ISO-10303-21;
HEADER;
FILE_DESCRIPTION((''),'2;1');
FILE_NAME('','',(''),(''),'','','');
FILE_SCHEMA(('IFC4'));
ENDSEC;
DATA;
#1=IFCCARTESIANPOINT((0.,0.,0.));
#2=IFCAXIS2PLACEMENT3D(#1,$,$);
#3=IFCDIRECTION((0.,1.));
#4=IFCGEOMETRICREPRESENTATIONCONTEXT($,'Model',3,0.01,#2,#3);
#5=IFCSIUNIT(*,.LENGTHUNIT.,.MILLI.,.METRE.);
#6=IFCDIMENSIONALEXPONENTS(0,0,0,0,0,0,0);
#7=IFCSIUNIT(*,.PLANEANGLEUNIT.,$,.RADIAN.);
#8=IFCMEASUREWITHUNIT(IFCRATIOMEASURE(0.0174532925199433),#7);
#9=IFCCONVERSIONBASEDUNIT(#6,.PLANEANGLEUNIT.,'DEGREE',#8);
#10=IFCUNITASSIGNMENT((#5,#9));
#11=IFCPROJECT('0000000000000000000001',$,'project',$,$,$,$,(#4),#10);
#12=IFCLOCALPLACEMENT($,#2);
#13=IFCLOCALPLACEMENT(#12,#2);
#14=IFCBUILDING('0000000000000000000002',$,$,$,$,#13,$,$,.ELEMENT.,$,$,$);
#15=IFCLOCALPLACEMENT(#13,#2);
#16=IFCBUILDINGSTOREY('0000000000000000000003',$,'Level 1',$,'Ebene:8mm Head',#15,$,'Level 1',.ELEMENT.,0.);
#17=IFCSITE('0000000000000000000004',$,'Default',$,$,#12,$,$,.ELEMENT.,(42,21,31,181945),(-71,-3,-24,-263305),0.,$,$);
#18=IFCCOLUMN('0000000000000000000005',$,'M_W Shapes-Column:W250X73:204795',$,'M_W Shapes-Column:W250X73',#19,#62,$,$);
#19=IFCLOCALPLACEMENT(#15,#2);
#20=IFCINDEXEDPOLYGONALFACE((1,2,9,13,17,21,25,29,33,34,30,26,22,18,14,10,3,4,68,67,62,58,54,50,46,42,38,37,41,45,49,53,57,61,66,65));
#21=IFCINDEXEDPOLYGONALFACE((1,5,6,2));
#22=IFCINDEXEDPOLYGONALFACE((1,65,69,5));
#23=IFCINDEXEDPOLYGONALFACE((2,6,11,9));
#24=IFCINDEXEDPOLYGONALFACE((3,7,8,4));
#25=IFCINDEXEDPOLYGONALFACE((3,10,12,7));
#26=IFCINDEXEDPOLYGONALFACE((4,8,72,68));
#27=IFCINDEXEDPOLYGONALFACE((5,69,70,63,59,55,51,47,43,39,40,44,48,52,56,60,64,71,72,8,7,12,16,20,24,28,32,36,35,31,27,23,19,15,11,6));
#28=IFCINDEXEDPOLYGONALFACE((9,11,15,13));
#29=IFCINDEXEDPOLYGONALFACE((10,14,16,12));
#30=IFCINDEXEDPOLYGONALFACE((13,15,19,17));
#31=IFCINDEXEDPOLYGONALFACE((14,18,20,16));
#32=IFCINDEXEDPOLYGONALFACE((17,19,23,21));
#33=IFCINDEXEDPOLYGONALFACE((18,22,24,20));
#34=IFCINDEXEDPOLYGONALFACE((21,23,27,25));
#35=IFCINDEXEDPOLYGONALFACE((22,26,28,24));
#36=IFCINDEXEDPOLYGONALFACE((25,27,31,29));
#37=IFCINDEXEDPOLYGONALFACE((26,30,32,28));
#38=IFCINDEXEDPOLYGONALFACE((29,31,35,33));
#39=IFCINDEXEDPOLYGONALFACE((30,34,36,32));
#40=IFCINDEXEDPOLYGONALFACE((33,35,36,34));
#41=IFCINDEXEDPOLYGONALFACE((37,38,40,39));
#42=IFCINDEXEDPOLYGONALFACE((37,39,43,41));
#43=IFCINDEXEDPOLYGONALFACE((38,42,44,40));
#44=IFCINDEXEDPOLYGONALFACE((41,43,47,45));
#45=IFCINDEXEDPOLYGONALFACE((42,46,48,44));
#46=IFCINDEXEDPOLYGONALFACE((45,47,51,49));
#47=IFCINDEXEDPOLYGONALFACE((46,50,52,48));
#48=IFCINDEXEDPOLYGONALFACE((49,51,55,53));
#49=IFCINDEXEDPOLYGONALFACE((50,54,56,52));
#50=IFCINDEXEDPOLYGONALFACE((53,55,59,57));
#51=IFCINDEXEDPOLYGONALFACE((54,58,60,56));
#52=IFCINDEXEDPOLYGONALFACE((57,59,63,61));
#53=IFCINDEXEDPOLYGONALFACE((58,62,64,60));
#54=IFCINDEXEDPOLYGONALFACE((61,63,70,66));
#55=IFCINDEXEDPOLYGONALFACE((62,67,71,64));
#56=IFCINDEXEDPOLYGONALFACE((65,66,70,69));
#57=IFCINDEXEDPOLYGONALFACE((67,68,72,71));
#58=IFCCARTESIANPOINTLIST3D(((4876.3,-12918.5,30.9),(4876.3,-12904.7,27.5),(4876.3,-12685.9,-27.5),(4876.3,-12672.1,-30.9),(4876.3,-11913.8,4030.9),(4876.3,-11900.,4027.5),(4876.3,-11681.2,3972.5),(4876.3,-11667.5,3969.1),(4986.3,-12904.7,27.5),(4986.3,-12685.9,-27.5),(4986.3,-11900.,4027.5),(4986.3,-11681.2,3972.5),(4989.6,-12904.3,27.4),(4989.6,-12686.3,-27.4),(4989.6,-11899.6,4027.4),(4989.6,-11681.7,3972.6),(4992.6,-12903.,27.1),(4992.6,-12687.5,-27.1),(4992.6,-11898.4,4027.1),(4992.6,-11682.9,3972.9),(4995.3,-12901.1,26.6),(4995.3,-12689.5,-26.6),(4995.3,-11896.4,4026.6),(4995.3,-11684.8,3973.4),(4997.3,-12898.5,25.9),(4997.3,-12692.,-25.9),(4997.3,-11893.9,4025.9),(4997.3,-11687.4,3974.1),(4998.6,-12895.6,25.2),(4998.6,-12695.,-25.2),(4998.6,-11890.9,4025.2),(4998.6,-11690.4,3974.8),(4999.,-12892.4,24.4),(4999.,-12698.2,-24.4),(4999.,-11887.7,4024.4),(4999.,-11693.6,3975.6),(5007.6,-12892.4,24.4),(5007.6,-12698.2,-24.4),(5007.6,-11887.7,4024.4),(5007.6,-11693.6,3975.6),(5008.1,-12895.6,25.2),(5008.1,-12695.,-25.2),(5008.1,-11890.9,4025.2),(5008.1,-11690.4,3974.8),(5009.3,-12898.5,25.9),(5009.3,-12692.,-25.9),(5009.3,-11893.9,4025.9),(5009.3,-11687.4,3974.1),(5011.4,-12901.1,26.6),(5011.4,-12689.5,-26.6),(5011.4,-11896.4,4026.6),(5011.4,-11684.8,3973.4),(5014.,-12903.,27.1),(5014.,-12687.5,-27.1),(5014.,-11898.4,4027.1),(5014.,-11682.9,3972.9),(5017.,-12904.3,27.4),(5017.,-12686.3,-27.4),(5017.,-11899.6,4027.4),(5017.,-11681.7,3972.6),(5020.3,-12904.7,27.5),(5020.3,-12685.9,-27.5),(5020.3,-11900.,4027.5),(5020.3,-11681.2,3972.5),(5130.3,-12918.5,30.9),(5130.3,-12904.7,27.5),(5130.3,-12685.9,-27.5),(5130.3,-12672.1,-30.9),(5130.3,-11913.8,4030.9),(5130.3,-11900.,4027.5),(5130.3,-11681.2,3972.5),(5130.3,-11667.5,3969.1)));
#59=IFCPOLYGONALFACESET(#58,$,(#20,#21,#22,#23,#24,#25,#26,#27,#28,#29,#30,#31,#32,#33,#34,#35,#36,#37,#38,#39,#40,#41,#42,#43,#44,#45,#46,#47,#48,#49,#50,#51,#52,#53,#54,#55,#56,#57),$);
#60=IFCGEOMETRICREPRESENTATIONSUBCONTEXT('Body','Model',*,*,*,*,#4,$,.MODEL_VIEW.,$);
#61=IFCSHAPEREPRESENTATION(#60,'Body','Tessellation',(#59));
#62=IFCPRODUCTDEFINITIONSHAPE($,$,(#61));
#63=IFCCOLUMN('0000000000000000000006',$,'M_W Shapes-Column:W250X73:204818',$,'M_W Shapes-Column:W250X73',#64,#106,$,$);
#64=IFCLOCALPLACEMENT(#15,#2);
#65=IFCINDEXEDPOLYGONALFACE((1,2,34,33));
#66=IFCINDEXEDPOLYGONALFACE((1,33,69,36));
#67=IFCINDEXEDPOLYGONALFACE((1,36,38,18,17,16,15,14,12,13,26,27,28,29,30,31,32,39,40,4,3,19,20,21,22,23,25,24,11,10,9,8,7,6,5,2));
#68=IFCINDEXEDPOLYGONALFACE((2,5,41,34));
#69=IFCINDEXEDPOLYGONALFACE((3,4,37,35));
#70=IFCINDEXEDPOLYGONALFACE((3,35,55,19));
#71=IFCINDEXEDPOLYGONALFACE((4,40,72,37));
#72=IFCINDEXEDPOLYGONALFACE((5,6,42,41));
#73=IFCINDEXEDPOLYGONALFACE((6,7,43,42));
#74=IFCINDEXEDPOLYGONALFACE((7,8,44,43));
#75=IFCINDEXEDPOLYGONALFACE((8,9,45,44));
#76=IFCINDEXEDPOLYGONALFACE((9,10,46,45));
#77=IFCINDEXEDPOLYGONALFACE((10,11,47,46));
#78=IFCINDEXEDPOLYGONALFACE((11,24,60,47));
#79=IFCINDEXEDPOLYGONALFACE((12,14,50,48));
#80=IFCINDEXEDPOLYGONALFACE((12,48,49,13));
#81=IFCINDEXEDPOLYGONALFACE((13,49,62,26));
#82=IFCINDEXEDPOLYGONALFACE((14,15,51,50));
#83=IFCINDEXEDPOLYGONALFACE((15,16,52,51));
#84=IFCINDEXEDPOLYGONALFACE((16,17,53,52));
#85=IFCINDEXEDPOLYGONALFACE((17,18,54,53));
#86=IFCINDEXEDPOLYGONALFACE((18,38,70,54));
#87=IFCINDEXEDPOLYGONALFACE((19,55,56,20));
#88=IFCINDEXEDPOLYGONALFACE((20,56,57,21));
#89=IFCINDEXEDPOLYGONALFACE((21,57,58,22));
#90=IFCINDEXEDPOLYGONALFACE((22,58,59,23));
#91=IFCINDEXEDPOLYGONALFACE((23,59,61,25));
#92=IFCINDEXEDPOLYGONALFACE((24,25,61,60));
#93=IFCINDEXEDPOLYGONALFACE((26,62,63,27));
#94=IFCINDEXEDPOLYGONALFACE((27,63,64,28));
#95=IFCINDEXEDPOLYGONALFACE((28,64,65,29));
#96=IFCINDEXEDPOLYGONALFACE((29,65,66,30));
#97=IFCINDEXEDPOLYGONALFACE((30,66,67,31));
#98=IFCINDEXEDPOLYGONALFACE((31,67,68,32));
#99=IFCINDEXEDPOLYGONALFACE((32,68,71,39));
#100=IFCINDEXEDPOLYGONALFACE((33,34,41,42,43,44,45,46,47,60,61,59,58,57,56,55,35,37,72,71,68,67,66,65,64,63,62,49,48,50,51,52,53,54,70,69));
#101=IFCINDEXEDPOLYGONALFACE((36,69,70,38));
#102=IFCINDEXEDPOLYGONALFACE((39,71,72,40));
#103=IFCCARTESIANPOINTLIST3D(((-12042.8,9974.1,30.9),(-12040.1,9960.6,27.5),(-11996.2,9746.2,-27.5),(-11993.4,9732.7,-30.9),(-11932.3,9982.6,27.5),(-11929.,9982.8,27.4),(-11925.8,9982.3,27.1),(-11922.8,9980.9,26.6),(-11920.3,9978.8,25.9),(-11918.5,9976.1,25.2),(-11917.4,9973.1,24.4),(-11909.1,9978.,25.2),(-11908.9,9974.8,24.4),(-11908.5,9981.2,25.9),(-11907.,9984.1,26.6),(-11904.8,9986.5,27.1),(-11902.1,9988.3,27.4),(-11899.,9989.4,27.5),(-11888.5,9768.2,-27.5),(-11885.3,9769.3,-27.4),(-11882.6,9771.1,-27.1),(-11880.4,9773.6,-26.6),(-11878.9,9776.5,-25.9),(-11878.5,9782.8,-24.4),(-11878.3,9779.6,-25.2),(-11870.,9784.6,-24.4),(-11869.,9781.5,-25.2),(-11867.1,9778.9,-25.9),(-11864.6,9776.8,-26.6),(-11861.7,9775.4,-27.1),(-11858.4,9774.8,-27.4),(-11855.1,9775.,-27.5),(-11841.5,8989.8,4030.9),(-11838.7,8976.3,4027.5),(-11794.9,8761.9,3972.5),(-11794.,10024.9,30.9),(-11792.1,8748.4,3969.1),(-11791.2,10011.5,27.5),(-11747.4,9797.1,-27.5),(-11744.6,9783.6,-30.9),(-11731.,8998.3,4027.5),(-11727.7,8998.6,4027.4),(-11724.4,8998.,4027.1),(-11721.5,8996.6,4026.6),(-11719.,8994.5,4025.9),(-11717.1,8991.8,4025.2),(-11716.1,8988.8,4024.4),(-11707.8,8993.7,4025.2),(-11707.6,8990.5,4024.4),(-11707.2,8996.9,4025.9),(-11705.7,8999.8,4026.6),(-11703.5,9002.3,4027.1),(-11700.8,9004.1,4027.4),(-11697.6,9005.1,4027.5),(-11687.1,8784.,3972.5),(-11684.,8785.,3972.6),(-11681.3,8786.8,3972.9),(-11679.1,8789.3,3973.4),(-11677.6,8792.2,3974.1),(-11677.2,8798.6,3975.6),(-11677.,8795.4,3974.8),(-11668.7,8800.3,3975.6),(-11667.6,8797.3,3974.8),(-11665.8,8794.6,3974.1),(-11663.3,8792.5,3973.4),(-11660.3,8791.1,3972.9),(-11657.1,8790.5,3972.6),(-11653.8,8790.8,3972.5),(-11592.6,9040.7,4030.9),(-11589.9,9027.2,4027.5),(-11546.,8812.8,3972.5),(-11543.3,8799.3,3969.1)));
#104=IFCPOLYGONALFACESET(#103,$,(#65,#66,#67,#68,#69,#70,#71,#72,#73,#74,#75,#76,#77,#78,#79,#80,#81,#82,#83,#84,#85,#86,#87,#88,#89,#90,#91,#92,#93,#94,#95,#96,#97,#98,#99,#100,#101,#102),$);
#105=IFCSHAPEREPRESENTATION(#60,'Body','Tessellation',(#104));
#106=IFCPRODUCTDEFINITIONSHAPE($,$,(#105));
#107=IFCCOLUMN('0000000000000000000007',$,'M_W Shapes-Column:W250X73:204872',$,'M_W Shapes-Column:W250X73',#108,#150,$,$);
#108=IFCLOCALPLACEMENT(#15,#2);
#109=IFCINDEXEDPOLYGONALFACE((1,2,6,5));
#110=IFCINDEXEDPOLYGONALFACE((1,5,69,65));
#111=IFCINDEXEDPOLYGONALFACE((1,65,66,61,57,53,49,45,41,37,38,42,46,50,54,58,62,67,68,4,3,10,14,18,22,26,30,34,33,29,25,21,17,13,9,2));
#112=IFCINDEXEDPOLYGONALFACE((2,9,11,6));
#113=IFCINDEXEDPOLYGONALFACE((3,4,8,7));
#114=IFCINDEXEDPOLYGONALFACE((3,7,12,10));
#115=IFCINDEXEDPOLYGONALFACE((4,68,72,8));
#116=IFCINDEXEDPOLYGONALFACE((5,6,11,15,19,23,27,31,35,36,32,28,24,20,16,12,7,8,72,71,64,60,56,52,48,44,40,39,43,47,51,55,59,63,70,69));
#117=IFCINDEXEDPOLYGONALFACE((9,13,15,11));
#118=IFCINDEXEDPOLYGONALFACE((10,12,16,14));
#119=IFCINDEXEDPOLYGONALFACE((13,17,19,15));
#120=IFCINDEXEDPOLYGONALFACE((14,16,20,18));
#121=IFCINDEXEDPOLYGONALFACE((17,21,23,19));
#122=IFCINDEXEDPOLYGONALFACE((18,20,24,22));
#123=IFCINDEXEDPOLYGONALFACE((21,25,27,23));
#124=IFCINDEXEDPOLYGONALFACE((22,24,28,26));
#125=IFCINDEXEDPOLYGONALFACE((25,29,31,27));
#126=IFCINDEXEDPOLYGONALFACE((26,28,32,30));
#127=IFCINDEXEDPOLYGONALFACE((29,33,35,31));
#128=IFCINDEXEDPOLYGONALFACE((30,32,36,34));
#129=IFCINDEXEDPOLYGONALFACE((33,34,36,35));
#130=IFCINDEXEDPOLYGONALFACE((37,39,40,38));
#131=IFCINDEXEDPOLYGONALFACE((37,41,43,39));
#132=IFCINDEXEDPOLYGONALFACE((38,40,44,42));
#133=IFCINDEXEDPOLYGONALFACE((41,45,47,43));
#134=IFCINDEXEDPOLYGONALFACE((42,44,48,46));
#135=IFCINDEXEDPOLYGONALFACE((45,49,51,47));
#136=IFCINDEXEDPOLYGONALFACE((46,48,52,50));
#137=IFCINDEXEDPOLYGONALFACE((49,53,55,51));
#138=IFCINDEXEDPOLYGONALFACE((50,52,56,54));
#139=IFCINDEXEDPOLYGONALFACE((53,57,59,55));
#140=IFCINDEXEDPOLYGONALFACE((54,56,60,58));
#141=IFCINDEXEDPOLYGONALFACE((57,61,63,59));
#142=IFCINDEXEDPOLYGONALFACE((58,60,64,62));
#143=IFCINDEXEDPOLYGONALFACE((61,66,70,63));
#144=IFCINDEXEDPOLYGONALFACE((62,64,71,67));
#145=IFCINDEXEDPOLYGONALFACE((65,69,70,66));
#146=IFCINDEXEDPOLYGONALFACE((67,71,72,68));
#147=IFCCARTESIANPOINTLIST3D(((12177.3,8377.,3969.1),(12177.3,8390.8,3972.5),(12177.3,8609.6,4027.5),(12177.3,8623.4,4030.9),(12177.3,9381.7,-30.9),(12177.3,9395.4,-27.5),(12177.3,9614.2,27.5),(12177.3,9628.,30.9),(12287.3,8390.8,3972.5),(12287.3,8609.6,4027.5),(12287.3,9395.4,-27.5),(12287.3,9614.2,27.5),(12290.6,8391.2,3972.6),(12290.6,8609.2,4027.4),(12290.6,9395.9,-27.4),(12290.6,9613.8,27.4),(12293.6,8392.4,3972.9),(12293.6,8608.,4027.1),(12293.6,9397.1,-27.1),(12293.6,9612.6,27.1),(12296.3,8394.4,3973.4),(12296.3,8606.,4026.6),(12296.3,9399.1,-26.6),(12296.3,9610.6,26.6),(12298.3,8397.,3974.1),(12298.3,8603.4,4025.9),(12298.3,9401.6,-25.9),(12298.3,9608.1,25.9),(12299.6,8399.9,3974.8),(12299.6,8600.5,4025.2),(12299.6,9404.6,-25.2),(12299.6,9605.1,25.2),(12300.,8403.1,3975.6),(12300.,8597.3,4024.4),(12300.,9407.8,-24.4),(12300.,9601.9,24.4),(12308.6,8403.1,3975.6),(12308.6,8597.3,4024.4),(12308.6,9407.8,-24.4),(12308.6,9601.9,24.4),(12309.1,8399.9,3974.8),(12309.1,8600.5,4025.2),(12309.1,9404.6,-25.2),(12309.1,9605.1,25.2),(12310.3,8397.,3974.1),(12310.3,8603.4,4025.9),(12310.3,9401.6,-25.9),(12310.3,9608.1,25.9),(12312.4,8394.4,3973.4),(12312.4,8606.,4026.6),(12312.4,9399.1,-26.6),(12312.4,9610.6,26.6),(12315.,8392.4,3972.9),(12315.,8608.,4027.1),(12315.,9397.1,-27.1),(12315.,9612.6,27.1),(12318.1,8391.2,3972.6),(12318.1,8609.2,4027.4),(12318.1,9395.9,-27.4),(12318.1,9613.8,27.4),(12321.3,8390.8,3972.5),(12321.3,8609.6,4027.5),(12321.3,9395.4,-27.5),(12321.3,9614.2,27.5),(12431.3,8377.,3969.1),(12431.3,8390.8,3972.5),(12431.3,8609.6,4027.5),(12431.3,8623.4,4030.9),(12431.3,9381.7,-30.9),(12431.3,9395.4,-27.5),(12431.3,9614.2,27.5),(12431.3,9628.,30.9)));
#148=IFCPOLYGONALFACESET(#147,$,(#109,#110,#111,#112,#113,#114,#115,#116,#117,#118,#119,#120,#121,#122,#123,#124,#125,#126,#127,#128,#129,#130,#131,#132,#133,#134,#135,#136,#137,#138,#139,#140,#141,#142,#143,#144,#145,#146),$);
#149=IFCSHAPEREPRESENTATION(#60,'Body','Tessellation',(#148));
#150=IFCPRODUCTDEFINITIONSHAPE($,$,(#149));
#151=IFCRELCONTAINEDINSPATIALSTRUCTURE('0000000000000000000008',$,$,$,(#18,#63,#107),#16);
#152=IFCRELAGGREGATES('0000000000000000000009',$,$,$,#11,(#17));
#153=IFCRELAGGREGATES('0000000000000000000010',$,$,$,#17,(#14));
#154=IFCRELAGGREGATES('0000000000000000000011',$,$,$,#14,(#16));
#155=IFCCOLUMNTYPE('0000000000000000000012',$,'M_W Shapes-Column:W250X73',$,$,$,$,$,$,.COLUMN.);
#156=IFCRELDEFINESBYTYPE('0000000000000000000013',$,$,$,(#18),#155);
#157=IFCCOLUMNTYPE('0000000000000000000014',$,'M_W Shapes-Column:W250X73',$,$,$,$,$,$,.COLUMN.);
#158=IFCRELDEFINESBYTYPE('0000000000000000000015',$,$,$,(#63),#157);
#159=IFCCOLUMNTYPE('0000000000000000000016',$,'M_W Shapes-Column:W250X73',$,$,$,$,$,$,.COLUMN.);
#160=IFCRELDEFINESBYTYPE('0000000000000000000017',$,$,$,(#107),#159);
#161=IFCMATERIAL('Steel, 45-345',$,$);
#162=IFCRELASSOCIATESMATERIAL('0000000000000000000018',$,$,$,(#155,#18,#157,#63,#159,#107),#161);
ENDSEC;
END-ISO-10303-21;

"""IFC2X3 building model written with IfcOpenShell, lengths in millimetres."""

from ifc_helpers import new_model, entity, si_unit, converted_unit, direction, frame, frame_2d, origin, place, context, subcontext, project, spatial, polyline, circle_curve, parameter, trimmed, segment, composite_curve, outline, extrude, source, transform, mapped, material, type_object, type_shapes, element, save


model = new_model("IFC2X3")

# Units and contexts
model_context = context("Model", 3, precision=0.01, world=origin(), true_north=direction((0.0, 1.0)))
body_context = subcontext(model_context, "Body", "Model", "MODEL_VIEW")
ifc_project = project(units=[si_unit("LENGTHUNIT", "METRE", prefix="MILLI"), converted_unit("PLANEANGLEUNIT", "DEGREE", entity("IfcRatioMeasure", 0.0174532925199433), si_unit("PLANEANGLEUNIT", "RADIAN"), dimensions=[0, 0, 0, 0, 0, 0, 0])], contexts=[model_context])

# Site, building, storey
site_placement = place(None, origin())
site = spatial("IfcSite", under=ifc_project, at=site_placement, Name="Default", CompositionType="ELEMENT", RefLatitude=(42, 21, 31, 181945), RefLongitude=(-71, -3, -24, -263305), RefElevation=0.0)
building_placement = place(site_placement, origin())
building = spatial("IfcBuilding", under=site, at=building_placement, CompositionType="ELEMENT")
storey_placement = place(building_placement, origin())
storey = spatial("IfcBuildingStorey", under=building, at=storey_placement, Name="Level 1", ObjectType="Ebene:8mm Head", LongName="Level 1", CompositionType="ELEMENT", Elevation=0.0)

# Columns
ifc_material_1 = material(Name="Steel, 45-345")
column_type_1 = type_object("IfcColumnType", Name="M_W Shapes-Column:W250X73", PredefinedType="COLUMN", material=ifc_material_1)
shared_shape_1 = source(origin(), body_context, "Body", "SweptSolid", [
    extrude(outline(composite_curve([segment(polyline([(112.8, -127.0), (127.0, -127.0)]), True, "CONTINUOUS"), segment(polyline([(127.0, -127.0), (127.0, 127.0)]), True, "CONTINUOUS"), segment(polyline([(127.0, 127.0), (112.8, 127.0)]), True, "CONTINUOUS"), segment(polyline([(112.8, 127.0), (112.8, 17.0)]), True, "CONTINUOUS"), segment(trimmed(circle_curve(frame_2d((100.1, 17.0), x_axis=(1.0, 0.0)), 12.7), [parameter(270.0)], [parameter(0.0)], True, "PARAMETER"), False, "CONTINUOUS"), segment(polyline([(100.1, 4.3), (-100.1, 4.3)]), True, "CONTINUOUS"), segment(trimmed(circle_curve(frame_2d((-100.1, 17.0), x_axis=(0.0, -1.0)), 12.7), [parameter(270.0)], [parameter(0.0)], True, "PARAMETER"), False, "CONTINUOUS"), segment(polyline([(-112.8, 17.0), (-112.8, 127.0)]), True, "CONTINUOUS"), segment(polyline([(-112.8, 127.0), (-127.0, 127.0)]), True, "CONTINUOUS"), segment(polyline([(-127.0, 127.0), (-127.0, -127.0)]), True, "CONTINUOUS"), segment(polyline([(-127.0, -127.0), (-112.8, -127.0)]), True, "CONTINUOUS"), segment(polyline([(-112.8, -127.0), (-112.8, -17.0)]), True, "CONTINUOUS"), segment(trimmed(circle_curve(frame_2d((-100.1, -17.0), x_axis=(-1.0, 0.0)), 12.7), [parameter(270.0)], [parameter(0.0)], True, "PARAMETER"), False, "CONTINUOUS"), segment(polyline([(-100.1, -4.3), (100.1, -4.3)]), True, "CONTINUOUS"), segment(trimmed(circle_curve(frame_2d((100.1, -17.0), x_axis=(0.0, 1.0)), 12.7), [parameter(270.0)], [parameter(0.0)], True, "PARAMETER"), False, "CONTINUOUS"), segment(polyline([(112.8, -17.0), (112.8, -127.0)]), True, "CONTINUOUS")], self_intersect=False)), frame((5003.3, -12795.3, 0.0), z_axis=(0.0, 0.243596, 0.969877), x_axis=(0.0, -0.969877, 0.243596)), (0.0, 0.0, 1.0), 4124.2),
])
type_shapes(column_type_1, [shared_shape_1])
column_1_placement = place(storey_placement, origin())
element("IfcColumn", 1, at=column_1_placement, inside=storey, type_object=column_type_1, material=ifc_material_1, Name="M_W Shapes-Column:W250X73:204795", ObjectType="M_W Shapes-Column:W250X73", context=body_context, shape_type="MappedRepresentation", body=[
    mapped(shared_shape_1, transform((0.0, 0.0, 0.0), scale=1.0)),
])
column_type_2 = type_object("IfcColumnType", Name="M_W Shapes-Column:W250X73", PredefinedType="COLUMN", material=ifc_material_1)
shared_shape_2 = source(origin(), body_context, "Body", "SweptSolid", [
    extrude(outline(composite_curve([segment(polyline([(112.8, -127.0), (127.0, -127.0)]), True, "CONTINUOUS"), segment(polyline([(127.0, -127.0), (127.0, 127.0)]), True, "CONTINUOUS"), segment(polyline([(127.0, 127.0), (112.8, 127.0)]), True, "CONTINUOUS"), segment(polyline([(112.8, 127.0), (112.8, 17.0)]), True, "CONTINUOUS"), segment(trimmed(circle_curve(frame_2d((100.1, 17.0), x_axis=(1.0, 0.0)), 12.7), [parameter(270.0)], [parameter(0.0)], True, "PARAMETER"), False, "CONTINUOUS"), segment(polyline([(100.1, 4.3), (-100.1, 4.3)]), True, "CONTINUOUS"), segment(trimmed(circle_curve(frame_2d((-100.1, 17.0), x_axis=(0.0, -1.0)), 12.7), [parameter(270.0)], [parameter(0.0)], True, "PARAMETER"), False, "CONTINUOUS"), segment(polyline([(-112.8, 17.0), (-112.8, 127.0)]), True, "CONTINUOUS"), segment(polyline([(-112.8, 127.0), (-127.0, 127.0)]), True, "CONTINUOUS"), segment(polyline([(-127.0, 127.0), (-127.0, -127.0)]), True, "CONTINUOUS"), segment(polyline([(-127.0, -127.0), (-112.8, -127.0)]), True, "CONTINUOUS"), segment(polyline([(-112.8, -127.0), (-112.8, -17.0)]), True, "CONTINUOUS"), segment(trimmed(circle_curve(frame_2d((-100.1, -17.0), x_axis=(-1.0, 0.0)), 12.7), [parameter(270.0)], [parameter(0.0)], True, "PARAMETER"), False, "CONTINUOUS"), segment(polyline([(-100.1, -4.3), (100.1, -4.3)]), True, "CONTINUOUS"), segment(trimmed(circle_curve(frame_2d((100.1, -17.0), x_axis=(0.0, 1.0)), 12.7), [parameter(270.0)], [parameter(0.0)], True, "PARAMETER"), False, "CONTINUOUS"), segment(polyline([(112.8, -17.0), (112.8, -127.0)]), True, "CONTINUOUS")], self_intersect=False)), frame((-11893.7, 9878.8, 0.0), z_axis=(0.048812, -0.238656, 0.969877), x_axis=(-0.194346, 0.950206, 0.243596)), (0.0, 0.0, 1.0), 4124.2),
])
type_shapes(column_type_2, [shared_shape_2])
column_2_placement = place(storey_placement, origin())
element("IfcColumn", 2, at=column_2_placement, inside=storey, type_object=column_type_2, material=ifc_material_1, Name="M_W Shapes-Column:W250X73:204818", ObjectType="M_W Shapes-Column:W250X73", context=body_context, shape_type="MappedRepresentation", body=[
    mapped(shared_shape_2, transform((0.0, 0.0, 0.0), scale=1.0)),
])
column_type_3 = type_object("IfcColumnType", Name="M_W Shapes-Column:W250X73", PredefinedType="COLUMN", material=ifc_material_1)
shared_shape_3 = source(origin(), body_context, "Body", "SweptSolid", [
    extrude(outline(composite_curve([segment(polyline([(112.8, -127.0), (127.0, -127.0)]), True, "CONTINUOUS"), segment(polyline([(127.0, -127.0), (127.0, 127.0)]), True, "CONTINUOUS"), segment(polyline([(127.0, 127.0), (112.8, 127.0)]), True, "CONTINUOUS"), segment(polyline([(112.8, 127.0), (112.8, 17.0)]), True, "CONTINUOUS"), segment(trimmed(circle_curve(frame_2d((100.1, 17.0), x_axis=(1.0, 0.0)), 12.7), [parameter(270.0)], [parameter(0.0)], True, "PARAMETER"), False, "CONTINUOUS"), segment(polyline([(100.1, 4.3), (-100.1, 4.3)]), True, "CONTINUOUS"), segment(trimmed(circle_curve(frame_2d((-100.1, 17.0), x_axis=(0.0, -1.0)), 12.7), [parameter(270.0)], [parameter(0.0)], True, "PARAMETER"), False, "CONTINUOUS"), segment(polyline([(-112.8, 17.0), (-112.8, 127.0)]), True, "CONTINUOUS"), segment(polyline([(-112.8, 127.0), (-127.0, 127.0)]), True, "CONTINUOUS"), segment(polyline([(-127.0, 127.0), (-127.0, -127.0)]), True, "CONTINUOUS"), segment(polyline([(-127.0, -127.0), (-112.8, -127.0)]), True, "CONTINUOUS"), segment(polyline([(-112.8, -127.0), (-112.8, -17.0)]), True, "CONTINUOUS"), segment(trimmed(circle_curve(frame_2d((-100.1, -17.0), x_axis=(-1.0, 0.0)), 12.7), [parameter(270.0)], [parameter(0.0)], True, "PARAMETER"), False, "CONTINUOUS"), segment(polyline([(-100.1, -4.3), (100.1, -4.3)]), True, "CONTINUOUS"), segment(trimmed(circle_curve(frame_2d((100.1, -17.0), x_axis=(0.0, 1.0)), 12.7), [parameter(270.0)], [parameter(0.0)], True, "PARAMETER"), False, "CONTINUOUS"), segment(polyline([(112.8, -17.0), (112.8, -127.0)]), True, "CONTINUOUS")], self_intersect=False)), frame((12304.3, 9504.8, 0.0), z_axis=(0.0, -0.243596, 0.969877), x_axis=(0.0, -0.969877, -0.243596)), (0.0, 0.0, 1.0), 4124.2),
])
type_shapes(column_type_3, [shared_shape_3])
column_3_placement = place(storey_placement, origin())
element("IfcColumn", 3, at=column_3_placement, inside=storey, type_object=column_type_3, material=ifc_material_1, Name="M_W Shapes-Column:W250X73:204872", ObjectType="M_W Shapes-Column:W250X73", context=body_context, shape_type="MappedRepresentation", body=[
    mapped(shared_shape_3, transform((0.0, 0.0, 0.0), scale=1.0)),
])

save(model, "model.ifc")
